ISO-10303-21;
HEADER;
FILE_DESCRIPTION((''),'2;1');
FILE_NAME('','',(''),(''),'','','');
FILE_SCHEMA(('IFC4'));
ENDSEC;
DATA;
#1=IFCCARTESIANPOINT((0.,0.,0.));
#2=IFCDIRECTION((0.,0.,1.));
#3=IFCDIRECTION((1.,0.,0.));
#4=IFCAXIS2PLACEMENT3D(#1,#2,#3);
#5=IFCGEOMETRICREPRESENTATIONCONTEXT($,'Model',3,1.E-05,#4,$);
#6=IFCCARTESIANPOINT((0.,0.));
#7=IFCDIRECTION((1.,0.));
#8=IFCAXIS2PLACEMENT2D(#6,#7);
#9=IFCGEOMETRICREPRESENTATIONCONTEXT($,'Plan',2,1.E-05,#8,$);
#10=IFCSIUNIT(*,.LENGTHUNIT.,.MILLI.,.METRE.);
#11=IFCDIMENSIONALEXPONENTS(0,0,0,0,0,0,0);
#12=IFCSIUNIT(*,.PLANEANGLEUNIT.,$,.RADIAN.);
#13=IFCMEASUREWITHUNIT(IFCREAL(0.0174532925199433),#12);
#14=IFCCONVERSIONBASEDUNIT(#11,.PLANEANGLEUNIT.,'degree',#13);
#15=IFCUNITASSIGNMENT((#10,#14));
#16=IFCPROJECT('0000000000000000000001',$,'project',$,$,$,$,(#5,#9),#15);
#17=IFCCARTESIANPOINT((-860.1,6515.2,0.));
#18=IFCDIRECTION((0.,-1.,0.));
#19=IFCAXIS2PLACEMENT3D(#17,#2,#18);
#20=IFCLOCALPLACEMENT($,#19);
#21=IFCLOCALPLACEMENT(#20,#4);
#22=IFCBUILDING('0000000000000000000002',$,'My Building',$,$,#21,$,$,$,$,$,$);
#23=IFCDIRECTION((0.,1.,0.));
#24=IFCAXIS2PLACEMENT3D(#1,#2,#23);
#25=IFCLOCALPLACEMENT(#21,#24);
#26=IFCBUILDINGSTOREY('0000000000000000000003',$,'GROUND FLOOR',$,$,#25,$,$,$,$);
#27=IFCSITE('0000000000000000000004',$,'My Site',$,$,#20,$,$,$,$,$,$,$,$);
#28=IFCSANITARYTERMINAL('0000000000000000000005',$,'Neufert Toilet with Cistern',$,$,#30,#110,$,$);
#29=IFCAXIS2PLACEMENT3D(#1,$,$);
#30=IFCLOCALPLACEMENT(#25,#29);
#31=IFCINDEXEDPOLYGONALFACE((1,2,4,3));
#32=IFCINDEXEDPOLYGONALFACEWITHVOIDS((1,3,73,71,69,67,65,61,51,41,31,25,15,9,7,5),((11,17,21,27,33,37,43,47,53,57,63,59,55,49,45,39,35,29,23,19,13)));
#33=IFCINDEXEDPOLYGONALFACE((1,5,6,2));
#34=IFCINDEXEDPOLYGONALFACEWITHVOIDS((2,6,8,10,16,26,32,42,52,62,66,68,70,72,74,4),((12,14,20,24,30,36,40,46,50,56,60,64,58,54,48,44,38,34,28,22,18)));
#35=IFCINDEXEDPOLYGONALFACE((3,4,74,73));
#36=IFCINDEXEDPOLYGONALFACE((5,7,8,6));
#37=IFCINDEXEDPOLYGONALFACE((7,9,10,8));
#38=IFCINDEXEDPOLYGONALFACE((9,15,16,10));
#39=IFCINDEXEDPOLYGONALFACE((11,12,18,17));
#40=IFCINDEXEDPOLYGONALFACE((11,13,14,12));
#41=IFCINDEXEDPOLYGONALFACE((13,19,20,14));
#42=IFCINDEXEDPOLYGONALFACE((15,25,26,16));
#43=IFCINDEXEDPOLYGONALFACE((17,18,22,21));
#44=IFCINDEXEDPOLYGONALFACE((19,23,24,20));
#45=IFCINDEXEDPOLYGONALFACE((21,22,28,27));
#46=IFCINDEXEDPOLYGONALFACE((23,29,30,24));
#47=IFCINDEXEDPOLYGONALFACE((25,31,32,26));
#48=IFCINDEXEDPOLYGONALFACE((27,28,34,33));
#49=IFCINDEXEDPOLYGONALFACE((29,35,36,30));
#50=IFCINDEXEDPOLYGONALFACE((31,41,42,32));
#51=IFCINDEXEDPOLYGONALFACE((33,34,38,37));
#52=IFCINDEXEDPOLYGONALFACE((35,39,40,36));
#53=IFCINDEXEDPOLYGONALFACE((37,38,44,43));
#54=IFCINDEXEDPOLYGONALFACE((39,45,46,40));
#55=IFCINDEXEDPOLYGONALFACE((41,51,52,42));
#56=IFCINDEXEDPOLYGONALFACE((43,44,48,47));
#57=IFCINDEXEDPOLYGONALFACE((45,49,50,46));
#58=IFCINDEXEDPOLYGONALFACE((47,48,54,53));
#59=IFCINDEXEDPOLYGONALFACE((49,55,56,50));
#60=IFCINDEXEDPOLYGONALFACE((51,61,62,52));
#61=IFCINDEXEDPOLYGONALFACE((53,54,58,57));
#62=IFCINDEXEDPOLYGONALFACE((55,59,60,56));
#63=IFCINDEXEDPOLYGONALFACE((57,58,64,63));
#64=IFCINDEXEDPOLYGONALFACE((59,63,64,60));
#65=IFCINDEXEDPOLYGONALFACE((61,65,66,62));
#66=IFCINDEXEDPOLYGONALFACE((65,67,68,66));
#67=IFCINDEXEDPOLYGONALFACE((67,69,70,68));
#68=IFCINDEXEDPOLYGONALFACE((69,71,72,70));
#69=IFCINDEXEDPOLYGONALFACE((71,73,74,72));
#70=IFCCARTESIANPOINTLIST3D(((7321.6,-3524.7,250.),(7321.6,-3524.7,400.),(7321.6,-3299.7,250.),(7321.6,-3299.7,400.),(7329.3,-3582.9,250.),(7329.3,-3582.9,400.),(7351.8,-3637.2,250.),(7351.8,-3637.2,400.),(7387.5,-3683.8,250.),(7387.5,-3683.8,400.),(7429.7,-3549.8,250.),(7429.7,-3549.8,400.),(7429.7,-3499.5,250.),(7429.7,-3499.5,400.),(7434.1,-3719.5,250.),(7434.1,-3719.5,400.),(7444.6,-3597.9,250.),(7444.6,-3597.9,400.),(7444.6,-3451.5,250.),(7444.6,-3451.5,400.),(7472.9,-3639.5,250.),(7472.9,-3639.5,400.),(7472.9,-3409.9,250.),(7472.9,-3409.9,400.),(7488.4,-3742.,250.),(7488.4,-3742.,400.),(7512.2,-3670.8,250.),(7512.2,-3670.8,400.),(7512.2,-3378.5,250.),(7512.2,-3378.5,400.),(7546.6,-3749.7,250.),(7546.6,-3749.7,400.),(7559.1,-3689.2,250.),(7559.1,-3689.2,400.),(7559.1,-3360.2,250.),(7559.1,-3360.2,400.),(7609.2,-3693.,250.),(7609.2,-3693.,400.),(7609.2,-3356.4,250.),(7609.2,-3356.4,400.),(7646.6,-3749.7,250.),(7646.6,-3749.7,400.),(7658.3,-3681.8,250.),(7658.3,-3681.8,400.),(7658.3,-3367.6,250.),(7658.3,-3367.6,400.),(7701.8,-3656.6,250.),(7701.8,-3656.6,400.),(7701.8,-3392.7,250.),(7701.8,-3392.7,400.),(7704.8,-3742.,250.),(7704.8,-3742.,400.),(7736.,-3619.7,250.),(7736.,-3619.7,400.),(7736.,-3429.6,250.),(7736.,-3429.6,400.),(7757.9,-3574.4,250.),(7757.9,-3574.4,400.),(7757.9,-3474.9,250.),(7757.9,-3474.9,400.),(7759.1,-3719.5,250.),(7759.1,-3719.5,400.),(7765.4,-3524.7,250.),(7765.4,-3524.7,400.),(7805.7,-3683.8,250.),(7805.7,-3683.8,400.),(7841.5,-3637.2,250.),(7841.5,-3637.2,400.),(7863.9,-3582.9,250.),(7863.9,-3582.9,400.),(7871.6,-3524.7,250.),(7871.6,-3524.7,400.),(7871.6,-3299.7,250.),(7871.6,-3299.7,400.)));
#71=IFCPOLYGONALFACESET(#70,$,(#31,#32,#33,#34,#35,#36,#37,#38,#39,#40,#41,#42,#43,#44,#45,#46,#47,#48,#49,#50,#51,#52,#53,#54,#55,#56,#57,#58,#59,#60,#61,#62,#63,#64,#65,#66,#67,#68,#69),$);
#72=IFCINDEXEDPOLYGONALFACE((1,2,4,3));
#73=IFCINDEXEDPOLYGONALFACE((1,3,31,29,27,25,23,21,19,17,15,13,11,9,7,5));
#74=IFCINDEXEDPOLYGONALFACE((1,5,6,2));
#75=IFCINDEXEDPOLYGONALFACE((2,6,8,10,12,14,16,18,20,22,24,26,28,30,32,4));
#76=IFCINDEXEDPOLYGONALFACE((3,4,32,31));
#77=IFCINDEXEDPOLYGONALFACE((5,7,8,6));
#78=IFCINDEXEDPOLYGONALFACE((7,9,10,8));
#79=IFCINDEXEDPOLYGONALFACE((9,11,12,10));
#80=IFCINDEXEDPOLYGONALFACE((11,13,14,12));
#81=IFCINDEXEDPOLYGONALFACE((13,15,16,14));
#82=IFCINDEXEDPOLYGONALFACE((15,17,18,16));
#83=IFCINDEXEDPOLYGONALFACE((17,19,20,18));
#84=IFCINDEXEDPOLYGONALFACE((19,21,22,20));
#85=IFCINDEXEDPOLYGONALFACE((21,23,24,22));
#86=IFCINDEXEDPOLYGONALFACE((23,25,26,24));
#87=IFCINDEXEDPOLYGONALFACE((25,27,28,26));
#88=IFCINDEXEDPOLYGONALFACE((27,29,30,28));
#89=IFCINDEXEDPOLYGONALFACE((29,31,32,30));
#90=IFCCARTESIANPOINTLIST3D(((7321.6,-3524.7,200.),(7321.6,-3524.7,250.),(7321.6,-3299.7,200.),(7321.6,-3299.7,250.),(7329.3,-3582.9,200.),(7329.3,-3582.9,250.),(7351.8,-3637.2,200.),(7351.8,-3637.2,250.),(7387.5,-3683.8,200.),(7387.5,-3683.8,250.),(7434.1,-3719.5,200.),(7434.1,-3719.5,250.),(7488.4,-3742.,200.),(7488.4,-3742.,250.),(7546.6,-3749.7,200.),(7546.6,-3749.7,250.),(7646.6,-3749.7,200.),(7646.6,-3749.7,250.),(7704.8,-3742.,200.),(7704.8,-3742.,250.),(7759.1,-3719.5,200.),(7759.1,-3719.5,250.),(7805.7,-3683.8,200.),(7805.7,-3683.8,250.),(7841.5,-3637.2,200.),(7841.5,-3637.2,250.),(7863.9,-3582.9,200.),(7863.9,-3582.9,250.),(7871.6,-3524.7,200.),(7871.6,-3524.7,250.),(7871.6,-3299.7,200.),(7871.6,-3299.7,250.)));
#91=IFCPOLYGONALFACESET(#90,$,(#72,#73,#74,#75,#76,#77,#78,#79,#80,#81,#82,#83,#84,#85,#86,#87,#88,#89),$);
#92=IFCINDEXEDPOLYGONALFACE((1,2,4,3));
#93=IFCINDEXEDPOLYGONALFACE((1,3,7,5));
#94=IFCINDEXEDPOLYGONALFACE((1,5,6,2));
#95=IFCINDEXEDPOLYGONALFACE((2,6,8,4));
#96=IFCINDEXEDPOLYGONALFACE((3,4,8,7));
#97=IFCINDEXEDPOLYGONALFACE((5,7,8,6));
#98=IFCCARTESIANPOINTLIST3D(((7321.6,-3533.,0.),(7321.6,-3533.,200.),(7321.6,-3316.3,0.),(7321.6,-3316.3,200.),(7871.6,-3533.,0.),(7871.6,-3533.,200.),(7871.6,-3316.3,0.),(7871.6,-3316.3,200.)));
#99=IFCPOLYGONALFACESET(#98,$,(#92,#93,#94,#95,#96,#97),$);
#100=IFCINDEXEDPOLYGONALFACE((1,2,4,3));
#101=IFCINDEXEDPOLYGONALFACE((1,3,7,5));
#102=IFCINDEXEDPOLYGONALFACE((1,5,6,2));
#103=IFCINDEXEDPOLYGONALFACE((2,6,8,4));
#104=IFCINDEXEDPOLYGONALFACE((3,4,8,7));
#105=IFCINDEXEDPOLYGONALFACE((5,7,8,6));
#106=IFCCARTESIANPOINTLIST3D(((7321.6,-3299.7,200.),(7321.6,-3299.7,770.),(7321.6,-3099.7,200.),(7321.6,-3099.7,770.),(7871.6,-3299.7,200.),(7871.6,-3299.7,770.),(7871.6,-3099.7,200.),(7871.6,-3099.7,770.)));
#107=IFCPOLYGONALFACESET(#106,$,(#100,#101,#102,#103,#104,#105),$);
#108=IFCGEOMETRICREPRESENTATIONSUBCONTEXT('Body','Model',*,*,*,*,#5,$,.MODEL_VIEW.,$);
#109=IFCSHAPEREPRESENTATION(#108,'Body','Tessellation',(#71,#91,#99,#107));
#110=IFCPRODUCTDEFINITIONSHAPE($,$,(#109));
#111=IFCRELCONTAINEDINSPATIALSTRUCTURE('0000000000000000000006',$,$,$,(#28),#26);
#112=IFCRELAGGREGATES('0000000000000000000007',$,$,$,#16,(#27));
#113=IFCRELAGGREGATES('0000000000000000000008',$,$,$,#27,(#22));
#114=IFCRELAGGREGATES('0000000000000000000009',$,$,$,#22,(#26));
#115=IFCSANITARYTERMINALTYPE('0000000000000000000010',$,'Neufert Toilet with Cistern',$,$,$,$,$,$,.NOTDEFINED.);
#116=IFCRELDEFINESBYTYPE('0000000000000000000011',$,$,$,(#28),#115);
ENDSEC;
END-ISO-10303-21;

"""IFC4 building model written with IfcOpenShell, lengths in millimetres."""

from ifc_helpers import new_model, entity, si_unit, converted_unit, frame, frame_2d, origin_with_axes, origin_2d_with_axis, place, context, subcontext, project, spatial, line, arc, indexed_curve, circle_curve, outline, extrude, shape, source, transform, mapped, type_object, type_shapes, element, save


model = new_model("IFC4")

# Units and contexts
model_context = context("Model", 3, precision=1e-05, world=origin_with_axes())
plan_context = context("Plan", 2, precision=1e-05, world=origin_2d_with_axis())
body_context_1 = subcontext(model_context, "Body", "Model", "MODEL_VIEW")
body_context_2 = subcontext(plan_context, "Body", "Plan", "PLAN_VIEW")
ifc_project = project(units=[si_unit("LENGTHUNIT", "METRE", prefix="MILLI"), converted_unit("PLANEANGLEUNIT", "degree", entity("IfcReal", 0.0174532925199433), si_unit("PLANEANGLEUNIT", "RADIAN"), dimensions=[0, 0, 0, 0, 0, 0, 0])], contexts=[model_context, plan_context])

# Site, building, storey
site_placement = place(None, frame((-860.1, 6515.2, 0.0), z_axis=(0.0, 0.0, 1.0), x_axis=(0.0, -1.0, 0.0)))
site = spatial("IfcSite", under=ifc_project, at=site_placement, Name="My Site")
building_placement = place(site_placement, frame((0.0, 0.0, 0.0), z_axis=(0.0, 0.0, 1.0), x_axis=(1.0, 0.0, 0.0)))
building = spatial("IfcBuilding", under=site, at=building_placement, Name="My Building")
storey_placement = place(building_placement, frame((0.0, 0.0, 0.0), z_axis=(0.0, 0.0, 1.0), x_axis=(0.0, 1.0, 0.0)))
storey = spatial("IfcBuildingStorey", under=building, at=storey_placement, Name="GROUND FLOOR")

# Sanitary terminal
sanitary_terminal_type_1 = type_object("IfcSanitaryTerminalType", Name="Neufert Toilet with Cistern", PredefinedType="NOTDEFINED")
shared_shape_1 = source(origin_with_axes(), body_context_1, "Body", "SweptSolid", [
    extrude(outline(indexed_curve([(-275.0, -200.0), (275.0, -200.0), (275.0, -425.0), (209.1, -584.1), (50.0, -650.0), (-50.0, -650.0), (-209.1, -584.1), (-275.0, -425.0)], segments=[line(1, 2), line(2, 3), arc(3, 4, 5), line(5, 6), arc(6, 7, 8), line(8, 1)]), holes=[circle_curve(frame_2d((0.0, -425.0)), 168.8)]), frame((0.0, 0.0, 250.0), z_axis=(0.0, 0.0, 1.0), x_axis=(1.0, 0.0, 0.0)), (0.0, 0.0, 1.0), 150.0),
    extrude(outline(indexed_curve([(-275.0, -200.0), (275.0, -200.0), (275.0, -425.0), (209.1, -584.1), (50.0, -650.0), (-50.0, -650.0), (-209.1, -584.1), (-275.0, -425.0)], segments=[line(1, 2), line(2, 3), arc(3, 4, 5), line(5, 6), arc(6, 7, 8), line(8, 1)])), frame((0.0, 0.0, 200.0), z_axis=(0.0, 0.0, 1.0), x_axis=(1.0, 0.0, 0.0)), (0.0, 0.0, 1.0), 50.0),
    extrude(outline(indexed_curve([(-275.0, -216.7), (275.0, -216.7), (275.0, -433.3), (-275.0, -433.3)], segments=[line(1, 2), line(2, 3), line(3, 4), line(4, 1)])), origin_with_axes(), (0.0, 0.0, 1.0), 200.0),
    extrude(outline(indexed_curve([(-275.0, 0.0), (275.0, 0.0), (275.0, -200.0), (-275.0, -200.0)], segments=[line(1, 2), line(2, 3), line(3, 4), line(4, 1)])), frame((0.0, 0.0, 200.0), z_axis=(0.0, 0.0, 1.0), x_axis=(1.0, 0.0, 0.0)), (0.0, 0.0, 1.0), 570.0),
])
shared_shape_2 = source(origin_with_axes(), body_context_2, "Body", "Curve2D", [
    entity("IfcIndexedPolyCurve", entity("IfcCartesianPointList2D", [[-275.0, 0.0], [275.0, 0.0], [275.0, -200.0], [-275.0, -200.0]]), [entity("IfcLineIndex", [1, 2]), entity("IfcLineIndex", [2, 3]), entity("IfcLineIndex", [3, 4]), entity("IfcLineIndex", [4, 1])]),
    entity("IfcIndexedPolyCurve", entity("IfcCartesianPointList2D", [[165.0, -200.0], [192.5, -335.0]]), [entity("IfcLineIndex", [1, 2])]),
    entity("IfcTrimmedCurve", entity("IfcEllipse", entity("IfcAxis2Placement2D", entity("IfcCartesianPoint", [0.0, -335.0]), entity("IfcDirection", [1.0, 0.0])), 192.5, 315.0), [entity("IfcCartesianPoint", [-192.5, -335.0])], [entity("IfcCartesianPoint", [192.5, -335.0])], True, "CARTESIAN"),
    entity("IfcIndexedPolyCurve", entity("IfcCartesianPointList2D", [[-165.0, -200.0], [-192.5, -335.0]]), [entity("IfcLineIndex", [1, 2])]),
    entity("IfcEllipse", entity("IfcAxis2Placement2D", entity("IfcCartesianPoint", [0.0, -452.0]), entity("IfcDirection", [1.0, 0.0])), 131.2, 157.5),
    entity("IfcIndexedPolyCurve", entity("IfcCartesianPointList2D", [[-34.4, -452.0], [-34.4, -429.5], [34.4, -429.5], [34.4, -452.0]]), [entity("IfcLineIndex", [1, 2]), entity("IfcLineIndex", [2, 3]), entity("IfcLineIndex", [3, 4])]),
    entity("IfcTrimmedCurve", entity("IfcEllipse", entity("IfcAxis2Placement2D", entity("IfcCartesianPoint", [0.0, -452.0]), entity("IfcDirection", [1.0, 0.0])), 34.4, 22.5), [entity("IfcCartesianPoint", [-34.4, -452.0])], [entity("IfcCartesianPoint", [34.4, -452.0])], True, "CARTESIAN"),
])
type_shapes(sanitary_terminal_type_1, [shared_shape_1, shared_shape_2])
for number, where, z_axis, x_axis, name in (
    (1, (7596.6, -3099.7, 0.0), (0.0, 0.0, 1.0), (1.0, 0.0, 0.0), "Neufert Toilet with Cistern"),
):
    element("IfcSanitaryTerminal", number, at=place(storey_placement, frame(where, z_axis=z_axis, x_axis=x_axis)), inside=storey, type_object=sanitary_terminal_type_1, Name=name, shapes=[
        shape(body_context_1, "Body", "MappedRepresentation", [mapped(shared_shape_1, transform((0.0, 0.0, 0.0), x_axis=(1.0, 0.0, 0.0), y_axis=(0.0, 1.0, 0.0), z_axis=(0.0, 0.0, 1.0), scale=1.0))]),
        shape(body_context_2, "Body", "MappedRepresentation", [mapped(shared_shape_2, transform((0.0, 0.0, 0.0), x_axis=(1.0, 0.0, 0.0), y_axis=(0.0, 1.0, 0.0), z_axis=(0.0, 0.0, 1.0), scale=1.0))]),
    ])

save(model, "model.ifc")
